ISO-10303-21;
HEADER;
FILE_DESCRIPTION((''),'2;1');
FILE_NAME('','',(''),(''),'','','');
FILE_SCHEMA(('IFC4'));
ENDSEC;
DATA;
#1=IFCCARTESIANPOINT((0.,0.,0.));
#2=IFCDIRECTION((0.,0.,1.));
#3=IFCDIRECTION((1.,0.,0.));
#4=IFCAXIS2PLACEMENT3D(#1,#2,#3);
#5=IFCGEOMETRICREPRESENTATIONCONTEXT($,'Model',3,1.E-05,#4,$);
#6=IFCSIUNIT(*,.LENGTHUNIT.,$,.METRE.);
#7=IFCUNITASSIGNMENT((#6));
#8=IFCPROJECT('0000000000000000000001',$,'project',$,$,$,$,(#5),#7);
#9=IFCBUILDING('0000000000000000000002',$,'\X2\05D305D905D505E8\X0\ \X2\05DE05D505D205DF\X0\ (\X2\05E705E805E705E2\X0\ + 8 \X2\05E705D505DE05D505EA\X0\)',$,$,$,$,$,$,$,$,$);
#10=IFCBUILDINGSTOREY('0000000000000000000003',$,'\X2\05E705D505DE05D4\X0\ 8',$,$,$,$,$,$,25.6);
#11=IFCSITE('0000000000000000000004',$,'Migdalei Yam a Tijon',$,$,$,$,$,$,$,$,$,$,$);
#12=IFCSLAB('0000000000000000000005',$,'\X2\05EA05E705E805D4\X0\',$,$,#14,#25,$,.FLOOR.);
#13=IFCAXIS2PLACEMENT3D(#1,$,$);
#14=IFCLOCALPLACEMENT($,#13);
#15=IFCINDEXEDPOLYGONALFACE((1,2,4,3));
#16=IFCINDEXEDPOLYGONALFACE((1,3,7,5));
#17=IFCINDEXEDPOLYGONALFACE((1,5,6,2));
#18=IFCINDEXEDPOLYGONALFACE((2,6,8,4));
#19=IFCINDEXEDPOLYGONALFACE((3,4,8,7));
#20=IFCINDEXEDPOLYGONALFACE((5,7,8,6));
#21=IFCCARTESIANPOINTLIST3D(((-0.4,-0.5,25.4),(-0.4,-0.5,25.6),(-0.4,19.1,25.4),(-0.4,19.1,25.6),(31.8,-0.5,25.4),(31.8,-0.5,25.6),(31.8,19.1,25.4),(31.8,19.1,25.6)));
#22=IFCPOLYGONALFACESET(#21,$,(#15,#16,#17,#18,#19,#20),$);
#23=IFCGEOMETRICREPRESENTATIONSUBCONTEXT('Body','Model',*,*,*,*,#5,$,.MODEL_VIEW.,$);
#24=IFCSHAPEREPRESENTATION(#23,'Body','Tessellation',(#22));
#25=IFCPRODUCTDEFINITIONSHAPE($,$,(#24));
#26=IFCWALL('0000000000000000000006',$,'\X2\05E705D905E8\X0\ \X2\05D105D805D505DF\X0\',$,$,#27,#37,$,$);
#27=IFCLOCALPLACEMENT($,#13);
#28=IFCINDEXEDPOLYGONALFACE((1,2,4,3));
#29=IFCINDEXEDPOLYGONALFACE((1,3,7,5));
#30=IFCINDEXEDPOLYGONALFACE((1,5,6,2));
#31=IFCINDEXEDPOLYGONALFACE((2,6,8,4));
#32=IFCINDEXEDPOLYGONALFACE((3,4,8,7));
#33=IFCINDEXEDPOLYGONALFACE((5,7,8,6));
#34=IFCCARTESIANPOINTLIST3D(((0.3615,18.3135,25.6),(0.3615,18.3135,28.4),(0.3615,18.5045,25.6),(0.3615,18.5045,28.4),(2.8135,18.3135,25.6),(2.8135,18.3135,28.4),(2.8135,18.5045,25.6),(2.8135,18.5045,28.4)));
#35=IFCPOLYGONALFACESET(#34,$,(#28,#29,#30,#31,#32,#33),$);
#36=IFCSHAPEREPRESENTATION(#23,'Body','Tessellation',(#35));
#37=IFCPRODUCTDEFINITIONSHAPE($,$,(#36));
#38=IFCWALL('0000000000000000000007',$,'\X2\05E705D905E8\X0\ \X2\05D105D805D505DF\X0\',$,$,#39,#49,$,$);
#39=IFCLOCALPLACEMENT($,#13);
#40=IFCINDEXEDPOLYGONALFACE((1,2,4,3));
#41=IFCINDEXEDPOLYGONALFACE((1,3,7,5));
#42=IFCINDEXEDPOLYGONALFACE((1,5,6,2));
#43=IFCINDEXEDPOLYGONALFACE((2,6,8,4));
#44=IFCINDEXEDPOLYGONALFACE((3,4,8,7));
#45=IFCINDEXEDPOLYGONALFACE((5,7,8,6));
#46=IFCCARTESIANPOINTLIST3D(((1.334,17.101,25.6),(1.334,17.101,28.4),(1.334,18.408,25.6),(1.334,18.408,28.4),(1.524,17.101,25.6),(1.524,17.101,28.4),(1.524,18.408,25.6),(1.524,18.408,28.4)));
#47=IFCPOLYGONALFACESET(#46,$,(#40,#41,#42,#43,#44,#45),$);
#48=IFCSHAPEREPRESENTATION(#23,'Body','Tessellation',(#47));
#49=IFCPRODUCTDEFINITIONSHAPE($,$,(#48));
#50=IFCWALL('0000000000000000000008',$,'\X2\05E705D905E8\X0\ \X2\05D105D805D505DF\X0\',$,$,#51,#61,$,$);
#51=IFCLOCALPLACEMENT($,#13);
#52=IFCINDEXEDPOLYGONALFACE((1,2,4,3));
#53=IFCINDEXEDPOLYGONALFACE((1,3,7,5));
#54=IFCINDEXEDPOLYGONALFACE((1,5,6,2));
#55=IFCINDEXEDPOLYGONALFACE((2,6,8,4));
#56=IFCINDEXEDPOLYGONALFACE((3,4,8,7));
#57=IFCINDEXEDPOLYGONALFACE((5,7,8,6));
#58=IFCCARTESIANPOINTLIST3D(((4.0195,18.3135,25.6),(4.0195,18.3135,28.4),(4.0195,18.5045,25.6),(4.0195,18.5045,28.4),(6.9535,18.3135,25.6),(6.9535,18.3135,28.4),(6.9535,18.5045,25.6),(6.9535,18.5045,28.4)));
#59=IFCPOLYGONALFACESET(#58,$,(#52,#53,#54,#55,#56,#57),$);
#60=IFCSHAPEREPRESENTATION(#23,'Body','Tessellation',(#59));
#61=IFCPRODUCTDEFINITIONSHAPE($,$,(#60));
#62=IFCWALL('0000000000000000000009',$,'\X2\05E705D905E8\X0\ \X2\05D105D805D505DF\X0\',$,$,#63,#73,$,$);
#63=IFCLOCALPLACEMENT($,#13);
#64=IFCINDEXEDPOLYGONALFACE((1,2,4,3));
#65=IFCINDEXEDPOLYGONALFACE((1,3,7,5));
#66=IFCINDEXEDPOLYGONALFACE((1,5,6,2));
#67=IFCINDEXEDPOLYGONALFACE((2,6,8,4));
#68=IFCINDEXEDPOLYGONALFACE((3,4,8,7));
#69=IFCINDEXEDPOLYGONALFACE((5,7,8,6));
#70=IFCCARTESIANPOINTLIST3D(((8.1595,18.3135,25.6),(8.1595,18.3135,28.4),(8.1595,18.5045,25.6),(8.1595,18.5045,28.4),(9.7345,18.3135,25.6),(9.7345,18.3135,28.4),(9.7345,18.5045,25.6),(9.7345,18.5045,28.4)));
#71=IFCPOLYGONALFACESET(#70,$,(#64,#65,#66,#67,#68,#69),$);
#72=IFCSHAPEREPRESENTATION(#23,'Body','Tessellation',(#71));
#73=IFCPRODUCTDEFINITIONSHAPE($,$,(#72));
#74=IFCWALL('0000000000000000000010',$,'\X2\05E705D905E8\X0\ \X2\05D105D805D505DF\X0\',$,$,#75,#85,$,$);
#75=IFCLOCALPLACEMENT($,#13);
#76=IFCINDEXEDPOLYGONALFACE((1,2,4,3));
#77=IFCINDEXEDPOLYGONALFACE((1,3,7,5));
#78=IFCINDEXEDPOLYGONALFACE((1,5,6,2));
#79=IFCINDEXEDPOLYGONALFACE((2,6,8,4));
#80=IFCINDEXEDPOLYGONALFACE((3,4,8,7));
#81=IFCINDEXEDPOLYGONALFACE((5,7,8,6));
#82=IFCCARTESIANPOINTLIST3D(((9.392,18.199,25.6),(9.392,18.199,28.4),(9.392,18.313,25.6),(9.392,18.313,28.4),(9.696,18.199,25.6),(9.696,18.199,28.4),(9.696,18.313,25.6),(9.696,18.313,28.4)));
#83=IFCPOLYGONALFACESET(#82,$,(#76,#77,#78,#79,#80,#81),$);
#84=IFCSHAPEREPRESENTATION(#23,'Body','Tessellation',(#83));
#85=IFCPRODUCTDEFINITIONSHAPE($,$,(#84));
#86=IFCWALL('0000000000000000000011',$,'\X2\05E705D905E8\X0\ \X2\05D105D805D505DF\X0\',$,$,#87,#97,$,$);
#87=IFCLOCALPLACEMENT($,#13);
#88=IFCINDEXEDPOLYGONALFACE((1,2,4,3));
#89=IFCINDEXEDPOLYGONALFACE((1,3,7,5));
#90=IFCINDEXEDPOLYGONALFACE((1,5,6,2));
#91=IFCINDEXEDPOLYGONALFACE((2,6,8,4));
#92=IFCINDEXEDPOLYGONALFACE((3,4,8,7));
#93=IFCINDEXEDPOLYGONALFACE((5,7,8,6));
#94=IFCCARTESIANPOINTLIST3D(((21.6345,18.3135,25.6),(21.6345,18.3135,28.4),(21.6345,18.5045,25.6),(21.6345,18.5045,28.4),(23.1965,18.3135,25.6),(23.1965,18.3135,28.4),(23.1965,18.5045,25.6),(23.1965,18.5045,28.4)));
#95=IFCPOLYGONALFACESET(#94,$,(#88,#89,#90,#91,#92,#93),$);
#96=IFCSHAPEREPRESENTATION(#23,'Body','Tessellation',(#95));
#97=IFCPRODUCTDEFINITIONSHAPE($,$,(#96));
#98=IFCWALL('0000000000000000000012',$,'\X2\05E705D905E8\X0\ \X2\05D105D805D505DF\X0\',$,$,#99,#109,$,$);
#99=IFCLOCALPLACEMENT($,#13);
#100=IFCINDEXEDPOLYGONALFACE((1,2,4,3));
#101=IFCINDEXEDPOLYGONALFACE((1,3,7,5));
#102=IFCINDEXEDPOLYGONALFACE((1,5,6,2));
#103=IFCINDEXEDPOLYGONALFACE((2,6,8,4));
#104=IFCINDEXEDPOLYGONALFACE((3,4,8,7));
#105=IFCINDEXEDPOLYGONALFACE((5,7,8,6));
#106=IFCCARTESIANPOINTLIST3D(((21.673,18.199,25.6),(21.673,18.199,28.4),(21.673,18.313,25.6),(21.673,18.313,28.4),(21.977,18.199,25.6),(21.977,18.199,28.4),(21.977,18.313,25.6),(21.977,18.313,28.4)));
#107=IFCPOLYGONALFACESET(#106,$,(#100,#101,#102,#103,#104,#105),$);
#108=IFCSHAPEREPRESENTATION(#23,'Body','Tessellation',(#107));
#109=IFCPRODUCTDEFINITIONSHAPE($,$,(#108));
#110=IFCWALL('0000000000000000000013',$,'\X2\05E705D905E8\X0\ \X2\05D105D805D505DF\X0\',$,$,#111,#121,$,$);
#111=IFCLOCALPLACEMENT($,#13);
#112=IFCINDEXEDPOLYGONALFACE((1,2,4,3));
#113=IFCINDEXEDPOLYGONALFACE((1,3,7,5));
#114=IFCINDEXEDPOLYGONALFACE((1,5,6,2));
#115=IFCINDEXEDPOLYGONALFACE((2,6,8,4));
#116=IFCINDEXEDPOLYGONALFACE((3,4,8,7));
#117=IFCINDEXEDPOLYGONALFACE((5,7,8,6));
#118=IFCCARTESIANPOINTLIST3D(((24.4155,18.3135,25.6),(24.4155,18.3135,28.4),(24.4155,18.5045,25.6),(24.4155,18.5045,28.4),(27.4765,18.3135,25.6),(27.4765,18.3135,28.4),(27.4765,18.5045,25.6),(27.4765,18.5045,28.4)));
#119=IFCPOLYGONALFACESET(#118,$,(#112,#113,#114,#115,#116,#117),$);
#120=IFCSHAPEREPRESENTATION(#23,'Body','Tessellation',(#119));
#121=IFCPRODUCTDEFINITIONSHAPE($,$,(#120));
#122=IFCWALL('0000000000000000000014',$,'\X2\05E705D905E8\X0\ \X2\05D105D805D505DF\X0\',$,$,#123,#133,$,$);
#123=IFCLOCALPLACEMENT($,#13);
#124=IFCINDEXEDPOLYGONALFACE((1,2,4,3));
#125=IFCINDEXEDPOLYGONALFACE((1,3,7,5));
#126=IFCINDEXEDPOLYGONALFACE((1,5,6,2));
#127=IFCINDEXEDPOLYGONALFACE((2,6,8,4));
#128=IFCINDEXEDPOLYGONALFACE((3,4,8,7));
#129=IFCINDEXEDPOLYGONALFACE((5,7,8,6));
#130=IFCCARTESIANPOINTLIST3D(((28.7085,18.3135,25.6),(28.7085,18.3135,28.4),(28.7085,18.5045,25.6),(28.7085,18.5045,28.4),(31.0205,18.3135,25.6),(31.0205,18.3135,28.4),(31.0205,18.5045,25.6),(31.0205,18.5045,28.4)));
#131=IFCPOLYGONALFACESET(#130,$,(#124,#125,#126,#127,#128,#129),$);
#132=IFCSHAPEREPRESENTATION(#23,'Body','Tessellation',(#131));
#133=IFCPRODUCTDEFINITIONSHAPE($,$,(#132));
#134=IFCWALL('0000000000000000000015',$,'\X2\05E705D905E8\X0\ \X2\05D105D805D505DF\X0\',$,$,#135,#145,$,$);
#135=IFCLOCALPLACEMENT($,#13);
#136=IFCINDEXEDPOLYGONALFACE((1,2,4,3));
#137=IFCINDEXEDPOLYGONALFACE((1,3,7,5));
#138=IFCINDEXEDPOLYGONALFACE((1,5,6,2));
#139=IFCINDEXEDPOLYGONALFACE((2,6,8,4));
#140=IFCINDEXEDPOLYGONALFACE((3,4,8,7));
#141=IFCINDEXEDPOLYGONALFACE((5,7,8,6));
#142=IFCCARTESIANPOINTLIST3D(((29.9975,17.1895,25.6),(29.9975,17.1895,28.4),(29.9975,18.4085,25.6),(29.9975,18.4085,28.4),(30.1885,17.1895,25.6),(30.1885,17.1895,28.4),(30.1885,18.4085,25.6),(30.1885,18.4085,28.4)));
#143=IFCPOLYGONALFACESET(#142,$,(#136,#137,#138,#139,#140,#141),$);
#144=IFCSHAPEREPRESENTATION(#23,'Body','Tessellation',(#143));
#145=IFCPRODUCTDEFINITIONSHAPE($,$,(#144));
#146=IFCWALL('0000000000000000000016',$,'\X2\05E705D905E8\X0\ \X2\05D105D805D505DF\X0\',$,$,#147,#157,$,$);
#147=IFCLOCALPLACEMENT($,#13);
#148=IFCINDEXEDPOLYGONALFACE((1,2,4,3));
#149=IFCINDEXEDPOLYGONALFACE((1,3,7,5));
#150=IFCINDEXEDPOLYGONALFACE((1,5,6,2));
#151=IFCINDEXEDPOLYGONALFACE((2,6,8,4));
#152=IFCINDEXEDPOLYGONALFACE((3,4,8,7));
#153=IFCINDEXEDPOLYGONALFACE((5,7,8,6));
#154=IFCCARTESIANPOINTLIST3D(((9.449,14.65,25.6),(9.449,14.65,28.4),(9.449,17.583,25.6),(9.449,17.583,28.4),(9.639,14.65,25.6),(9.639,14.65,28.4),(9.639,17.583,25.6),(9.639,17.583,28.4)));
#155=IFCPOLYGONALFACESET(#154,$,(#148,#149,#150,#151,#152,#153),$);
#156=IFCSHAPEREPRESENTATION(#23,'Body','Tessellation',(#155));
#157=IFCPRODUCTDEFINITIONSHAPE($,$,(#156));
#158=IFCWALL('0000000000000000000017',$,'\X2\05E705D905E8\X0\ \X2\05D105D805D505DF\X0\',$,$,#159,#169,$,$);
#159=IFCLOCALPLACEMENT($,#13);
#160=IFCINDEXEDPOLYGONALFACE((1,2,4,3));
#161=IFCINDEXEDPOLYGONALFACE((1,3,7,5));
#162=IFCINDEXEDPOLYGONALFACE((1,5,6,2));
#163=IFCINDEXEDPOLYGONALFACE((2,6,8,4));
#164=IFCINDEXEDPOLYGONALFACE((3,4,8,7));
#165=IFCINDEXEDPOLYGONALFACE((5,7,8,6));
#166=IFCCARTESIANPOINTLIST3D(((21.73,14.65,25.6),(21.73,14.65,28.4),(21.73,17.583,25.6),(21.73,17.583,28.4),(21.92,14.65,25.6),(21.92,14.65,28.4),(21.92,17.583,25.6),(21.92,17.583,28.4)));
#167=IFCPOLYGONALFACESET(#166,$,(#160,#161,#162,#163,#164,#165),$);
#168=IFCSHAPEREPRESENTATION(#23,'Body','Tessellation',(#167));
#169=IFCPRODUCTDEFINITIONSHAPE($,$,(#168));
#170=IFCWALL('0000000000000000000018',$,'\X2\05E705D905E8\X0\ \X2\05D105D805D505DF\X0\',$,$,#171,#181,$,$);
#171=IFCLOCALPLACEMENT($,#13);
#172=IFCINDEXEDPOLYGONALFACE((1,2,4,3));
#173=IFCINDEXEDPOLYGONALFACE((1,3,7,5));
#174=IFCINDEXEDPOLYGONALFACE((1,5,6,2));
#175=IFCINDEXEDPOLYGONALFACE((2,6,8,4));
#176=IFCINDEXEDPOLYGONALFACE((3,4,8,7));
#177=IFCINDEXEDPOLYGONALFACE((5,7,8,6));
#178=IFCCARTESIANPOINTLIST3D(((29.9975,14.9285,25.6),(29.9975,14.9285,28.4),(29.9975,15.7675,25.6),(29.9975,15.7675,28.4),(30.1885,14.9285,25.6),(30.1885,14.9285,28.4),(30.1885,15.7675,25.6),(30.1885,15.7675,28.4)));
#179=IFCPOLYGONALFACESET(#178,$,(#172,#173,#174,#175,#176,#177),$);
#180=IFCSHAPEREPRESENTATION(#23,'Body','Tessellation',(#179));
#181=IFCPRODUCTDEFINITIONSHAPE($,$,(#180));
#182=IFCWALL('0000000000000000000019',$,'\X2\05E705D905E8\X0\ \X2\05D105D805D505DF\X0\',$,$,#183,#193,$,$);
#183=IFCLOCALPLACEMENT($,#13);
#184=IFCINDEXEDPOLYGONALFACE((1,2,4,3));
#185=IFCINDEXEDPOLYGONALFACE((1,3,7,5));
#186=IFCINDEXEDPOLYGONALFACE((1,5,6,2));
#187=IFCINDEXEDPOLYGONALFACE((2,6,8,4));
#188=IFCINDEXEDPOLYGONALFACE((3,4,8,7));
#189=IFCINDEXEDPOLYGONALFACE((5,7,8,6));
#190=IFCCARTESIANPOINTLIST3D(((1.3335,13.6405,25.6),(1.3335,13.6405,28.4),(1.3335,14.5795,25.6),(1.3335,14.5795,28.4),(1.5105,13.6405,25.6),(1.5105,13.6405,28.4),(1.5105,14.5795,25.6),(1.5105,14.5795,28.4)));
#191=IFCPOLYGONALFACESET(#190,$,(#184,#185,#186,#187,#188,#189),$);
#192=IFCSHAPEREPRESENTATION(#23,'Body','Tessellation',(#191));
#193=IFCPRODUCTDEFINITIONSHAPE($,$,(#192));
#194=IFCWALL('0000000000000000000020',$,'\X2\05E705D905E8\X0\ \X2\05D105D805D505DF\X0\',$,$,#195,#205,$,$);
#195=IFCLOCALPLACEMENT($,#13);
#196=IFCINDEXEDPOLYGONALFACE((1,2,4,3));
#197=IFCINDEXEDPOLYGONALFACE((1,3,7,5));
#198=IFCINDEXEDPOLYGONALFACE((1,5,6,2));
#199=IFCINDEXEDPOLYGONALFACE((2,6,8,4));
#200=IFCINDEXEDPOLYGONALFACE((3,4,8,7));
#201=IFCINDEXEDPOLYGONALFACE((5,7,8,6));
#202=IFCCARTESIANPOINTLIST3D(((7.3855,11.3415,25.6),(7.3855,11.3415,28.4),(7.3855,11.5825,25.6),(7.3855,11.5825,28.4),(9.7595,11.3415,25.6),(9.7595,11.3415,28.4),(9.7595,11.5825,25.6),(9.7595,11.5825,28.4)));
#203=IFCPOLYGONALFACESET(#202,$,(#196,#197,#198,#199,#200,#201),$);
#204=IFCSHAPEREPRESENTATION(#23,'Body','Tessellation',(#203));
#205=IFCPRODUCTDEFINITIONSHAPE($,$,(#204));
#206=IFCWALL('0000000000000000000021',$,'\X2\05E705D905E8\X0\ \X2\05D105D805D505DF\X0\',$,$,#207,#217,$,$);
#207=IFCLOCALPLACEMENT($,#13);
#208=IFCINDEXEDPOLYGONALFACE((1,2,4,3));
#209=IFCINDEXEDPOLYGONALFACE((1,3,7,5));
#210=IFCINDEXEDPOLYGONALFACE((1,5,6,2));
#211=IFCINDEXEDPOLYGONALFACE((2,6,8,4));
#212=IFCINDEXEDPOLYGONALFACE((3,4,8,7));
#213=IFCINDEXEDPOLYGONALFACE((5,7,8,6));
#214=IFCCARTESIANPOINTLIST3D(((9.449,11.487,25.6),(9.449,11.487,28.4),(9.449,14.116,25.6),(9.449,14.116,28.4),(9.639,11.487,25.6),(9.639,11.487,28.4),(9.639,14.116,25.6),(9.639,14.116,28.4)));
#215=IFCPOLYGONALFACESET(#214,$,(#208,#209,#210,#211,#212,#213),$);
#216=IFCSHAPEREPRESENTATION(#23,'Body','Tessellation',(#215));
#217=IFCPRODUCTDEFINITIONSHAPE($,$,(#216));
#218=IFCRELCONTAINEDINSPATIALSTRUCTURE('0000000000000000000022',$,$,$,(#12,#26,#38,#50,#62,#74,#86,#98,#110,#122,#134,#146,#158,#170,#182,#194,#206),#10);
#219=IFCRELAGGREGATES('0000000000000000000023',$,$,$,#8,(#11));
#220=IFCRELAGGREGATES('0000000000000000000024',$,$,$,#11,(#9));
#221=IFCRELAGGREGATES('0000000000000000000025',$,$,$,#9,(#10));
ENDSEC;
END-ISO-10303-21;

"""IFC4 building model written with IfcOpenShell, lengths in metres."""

from ifc_helpers import new_model, si_unit, frame, origin_with_axes, context, subcontext, project, spatial, line, indexed_curve, outline, extrude, element, save


model = new_model("IFC4")

# Units and contexts
model_context = context("Model", 3, precision=1e-05, world=origin_with_axes())
body_context = subcontext(model_context, "Body", "Model", "MODEL_VIEW")
ifc_project = project(units=[si_unit("LENGTHUNIT", "METRE")], contexts=[model_context])

# Site, building, storey
site = spatial("IfcSite", under=ifc_project, Name="Migdalei Yam a Tijon")
building = spatial("IfcBuilding", under=site, Name="דיור מוגן (קרקע + 8 קומות)")
storey = spatial("IfcBuildingStorey", under=building, Name="קומה 8", Elevation=25.6)

# Slab
element("IfcSlab", 1, inside=storey, Name="תקרה", PredefinedType="FLOOR", context=body_context, shape_type="SweptSolid", body=[
    extrude(outline(indexed_curve([(0.0, 0.0), (32.2, 0.0), (32.2, 19.6), (0.0, 19.6)], segments=[line(1, 2, 3, 4, 1)])), frame((-0.4, -0.5, 25.4), z_axis=(0.0, 0.0, 1.0), x_axis=(1.0, 0.0, 0.0)), (0.0, 0.0, 1.0), 0.2),
])

# Walls
element("IfcWall", 2, inside=storey, Name="קיר בטון", context=body_context, shape_type="SweptSolid", body=[
    extrude(outline(indexed_curve([(0.0, 0.0), (2.452, 0.0), (2.452, 0.191), (0.0, 0.191)], segments=[line(1, 2, 3, 4, 1)])), frame((0.3615, 18.3135, 25.6), z_axis=(0.0, 0.0, 1.0), x_axis=(1.0, 0.0, 0.0)), (0.0, 0.0, 1.0), 2.8),
])
element("IfcWall", 3, inside=storey, Name="קיר בטון", context=body_context, shape_type="SweptSolid", body=[
    extrude(outline(indexed_curve([(0.0, 0.0), (0.19, 0.0), (0.19, 1.307), (0.0, 1.307)], segments=[line(1, 2, 3, 4, 1)])), frame((1.334, 17.101, 25.6), z_axis=(0.0, 0.0, 1.0), x_axis=(1.0, 0.0, 0.0)), (0.0, 0.0, 1.0), 2.8),
])
element("IfcWall", 4, inside=storey, Name="קיר בטון", context=body_context, shape_type="SweptSolid", body=[
    extrude(outline(indexed_curve([(0.0, 0.0), (2.934, 0.0), (2.934, 0.191), (0.0, 0.191)], segments=[line(1, 2, 3, 4, 1)])), frame((4.0195, 18.3135, 25.6), z_axis=(0.0, 0.0, 1.0), x_axis=(1.0, 0.0, 0.0)), (0.0, 0.0, 1.0), 2.8),
])
element("IfcWall", 5, inside=storey, Name="קיר בטון", context=body_context, shape_type="SweptSolid", body=[
    extrude(outline(indexed_curve([(0.0, 0.0), (1.575, 0.0), (1.575, 0.191), (0.0, 0.191)], segments=[line(1, 2, 3, 4, 1)])), frame((8.1595, 18.3135, 25.6), z_axis=(0.0, 0.0, 1.0), x_axis=(1.0, 0.0, 0.0)), (0.0, 0.0, 1.0), 2.8),
])
element("IfcWall", 6, inside=storey, Name="קיר בטון", context=body_context, shape_type="SweptSolid", body=[
    extrude(outline(indexed_curve([(0.0, 0.0), (0.304, 0.0), (0.304, 0.114), (0.0, 0.114)], segments=[line(1, 2, 3, 4, 1)])), frame((9.392, 18.199, 25.6), z_axis=(0.0, 0.0, 1.0), x_axis=(1.0, 0.0, 0.0)), (0.0, 0.0, 1.0), 2.8),
])
element("IfcWall", 7, inside=storey, Name="קיר בטון", context=body_context, shape_type="SweptSolid", body=[
    extrude(outline(indexed_curve([(0.0, 0.0), (1.562, 0.0), (1.562, 0.191), (0.0, 0.191)], segments=[line(1, 2, 3, 4, 1)])), frame((21.6345, 18.3135, 25.6), z_axis=(0.0, 0.0, 1.0), x_axis=(1.0, 0.0, 0.0)), (0.0, 0.0, 1.0), 2.8),
])
element("IfcWall", 8, inside=storey, Name="קיר בטון", context=body_context, shape_type="SweptSolid", body=[
    extrude(outline(indexed_curve([(0.0, 0.0), (0.304, 0.0), (0.304, 0.114), (0.0, 0.114)], segments=[line(1, 2, 3, 4, 1)])), frame((21.673, 18.199, 25.6), z_axis=(0.0, 0.0, 1.0), x_axis=(1.0, 0.0, 0.0)), (0.0, 0.0, 1.0), 2.8),
])
element("IfcWall", 9, inside=storey, Name="קיר בטון", context=body_context, shape_type="SweptSolid", body=[
    extrude(outline(indexed_curve([(0.0, 0.0), (3.061, 0.0), (3.061, 0.191), (0.0, 0.191)], segments=[line(1, 2, 3, 4, 1)])), frame((24.4155, 18.3135, 25.6), z_axis=(0.0, 0.0, 1.0), x_axis=(1.0, 0.0, 0.0)), (0.0, 0.0, 1.0), 2.8),
])
element("IfcWall", 10, inside=storey, Name="קיר בטון", context=body_context, shape_type="SweptSolid", body=[
    extrude(outline(indexed_curve([(0.0, 0.0), (2.312, 0.0), (2.312, 0.191), (0.0, 0.191)], segments=[line(1, 2, 3, 4, 1)])), frame((28.7085, 18.3135, 25.6), z_axis=(0.0, 0.0, 1.0), x_axis=(1.0, 0.0, 0.0)), (0.0, 0.0, 1.0), 2.8),
])
element("IfcWall", 11, inside=storey, Name="קיר בטון", context=body_context, shape_type="SweptSolid", body=[
    extrude(outline(indexed_curve([(0.0, 0.0), (0.191, 0.0), (0.191, 1.219), (0.0, 1.219)], segments=[line(1, 2, 3, 4, 1)])), frame((29.9975, 17.1895, 25.6), z_axis=(0.0, 0.0, 1.0), x_axis=(1.0, 0.0, 0.0)), (0.0, 0.0, 1.0), 2.8),
])
element("IfcWall", 12, inside=storey, Name="קיר בטון", context=body_context, shape_type="SweptSolid", body=[
    extrude(outline(indexed_curve([(0.0, 0.0), (0.19, 0.0), (0.19, 2.933), (0.0, 2.933)], segments=[line(1, 2, 3, 4, 1)])), frame((9.449, 14.65, 25.6), z_axis=(0.0, 0.0, 1.0), x_axis=(1.0, 0.0, 0.0)), (0.0, 0.0, 1.0), 2.8),
])
element("IfcWall", 13, inside=storey, Name="קיר בטון", context=body_context, shape_type="SweptSolid", body=[
    extrude(outline(indexed_curve([(0.0, 0.0), (0.19, 0.0), (0.19, 2.933), (0.0, 2.933)], segments=[line(1, 2, 3, 4, 1)])), frame((21.73, 14.65, 25.6), z_axis=(0.0, 0.0, 1.0), x_axis=(1.0, 0.0, 0.0)), (0.0, 0.0, 1.0), 2.8),
])
element("IfcWall", 14, inside=storey, Name="קיר בטון", context=body_context, shape_type="SweptSolid", body=[
    extrude(outline(indexed_curve([(0.0, 0.0), (0.191, 0.0), (0.191, 0.839), (0.0, 0.839)], segments=[line(1, 2, 3, 4, 1)])), frame((29.9975, 14.9285, 25.6), z_axis=(0.0, 0.0, 1.0), x_axis=(1.0, 0.0, 0.0)), (0.0, 0.0, 1.0), 2.8),
])
element("IfcWall", 15, inside=storey, Name="קיר בטון", context=body_context, shape_type="SweptSolid", body=[
    extrude(outline(indexed_curve([(0.0, 0.0), (0.177, 0.0), (0.177, 0.939), (0.0, 0.939)], segments=[line(1, 2, 3, 4, 1)])), frame((1.3335, 13.6405, 25.6), z_axis=(0.0, 0.0, 1.0), x_axis=(1.0, 0.0, 0.0)), (0.0, 0.0, 1.0), 2.8),
])
element("IfcWall", 16, inside=storey, Name="קיר בטון", context=body_context, shape_type="SweptSolid", body=[
    extrude(outline(indexed_curve([(0.0, 0.0), (2.374, 0.0), (2.374, 0.241), (0.0, 0.241)], segments=[line(1, 2, 3, 4, 1)])), frame((7.3855, 11.3415, 25.6), z_axis=(0.0, 0.0, 1.0), x_axis=(1.0, 0.0, 0.0)), (0.0, 0.0, 1.0), 2.8),
])
element("IfcWall", 17, inside=storey, Name="קיר בטון", context=body_context, shape_type="SweptSolid", body=[
    extrude(outline(indexed_curve([(0.0, 0.0), (0.19, 0.0), (0.19, 2.629), (0.0, 2.629)], segments=[line(1, 2, 3, 4, 1)])), frame((9.449, 11.487, 25.6), z_axis=(0.0, 0.0, 1.0), x_axis=(1.0, 0.0, 0.0)), (0.0, 0.0, 1.0), 2.8),
])

save(model, "model.ifc")
